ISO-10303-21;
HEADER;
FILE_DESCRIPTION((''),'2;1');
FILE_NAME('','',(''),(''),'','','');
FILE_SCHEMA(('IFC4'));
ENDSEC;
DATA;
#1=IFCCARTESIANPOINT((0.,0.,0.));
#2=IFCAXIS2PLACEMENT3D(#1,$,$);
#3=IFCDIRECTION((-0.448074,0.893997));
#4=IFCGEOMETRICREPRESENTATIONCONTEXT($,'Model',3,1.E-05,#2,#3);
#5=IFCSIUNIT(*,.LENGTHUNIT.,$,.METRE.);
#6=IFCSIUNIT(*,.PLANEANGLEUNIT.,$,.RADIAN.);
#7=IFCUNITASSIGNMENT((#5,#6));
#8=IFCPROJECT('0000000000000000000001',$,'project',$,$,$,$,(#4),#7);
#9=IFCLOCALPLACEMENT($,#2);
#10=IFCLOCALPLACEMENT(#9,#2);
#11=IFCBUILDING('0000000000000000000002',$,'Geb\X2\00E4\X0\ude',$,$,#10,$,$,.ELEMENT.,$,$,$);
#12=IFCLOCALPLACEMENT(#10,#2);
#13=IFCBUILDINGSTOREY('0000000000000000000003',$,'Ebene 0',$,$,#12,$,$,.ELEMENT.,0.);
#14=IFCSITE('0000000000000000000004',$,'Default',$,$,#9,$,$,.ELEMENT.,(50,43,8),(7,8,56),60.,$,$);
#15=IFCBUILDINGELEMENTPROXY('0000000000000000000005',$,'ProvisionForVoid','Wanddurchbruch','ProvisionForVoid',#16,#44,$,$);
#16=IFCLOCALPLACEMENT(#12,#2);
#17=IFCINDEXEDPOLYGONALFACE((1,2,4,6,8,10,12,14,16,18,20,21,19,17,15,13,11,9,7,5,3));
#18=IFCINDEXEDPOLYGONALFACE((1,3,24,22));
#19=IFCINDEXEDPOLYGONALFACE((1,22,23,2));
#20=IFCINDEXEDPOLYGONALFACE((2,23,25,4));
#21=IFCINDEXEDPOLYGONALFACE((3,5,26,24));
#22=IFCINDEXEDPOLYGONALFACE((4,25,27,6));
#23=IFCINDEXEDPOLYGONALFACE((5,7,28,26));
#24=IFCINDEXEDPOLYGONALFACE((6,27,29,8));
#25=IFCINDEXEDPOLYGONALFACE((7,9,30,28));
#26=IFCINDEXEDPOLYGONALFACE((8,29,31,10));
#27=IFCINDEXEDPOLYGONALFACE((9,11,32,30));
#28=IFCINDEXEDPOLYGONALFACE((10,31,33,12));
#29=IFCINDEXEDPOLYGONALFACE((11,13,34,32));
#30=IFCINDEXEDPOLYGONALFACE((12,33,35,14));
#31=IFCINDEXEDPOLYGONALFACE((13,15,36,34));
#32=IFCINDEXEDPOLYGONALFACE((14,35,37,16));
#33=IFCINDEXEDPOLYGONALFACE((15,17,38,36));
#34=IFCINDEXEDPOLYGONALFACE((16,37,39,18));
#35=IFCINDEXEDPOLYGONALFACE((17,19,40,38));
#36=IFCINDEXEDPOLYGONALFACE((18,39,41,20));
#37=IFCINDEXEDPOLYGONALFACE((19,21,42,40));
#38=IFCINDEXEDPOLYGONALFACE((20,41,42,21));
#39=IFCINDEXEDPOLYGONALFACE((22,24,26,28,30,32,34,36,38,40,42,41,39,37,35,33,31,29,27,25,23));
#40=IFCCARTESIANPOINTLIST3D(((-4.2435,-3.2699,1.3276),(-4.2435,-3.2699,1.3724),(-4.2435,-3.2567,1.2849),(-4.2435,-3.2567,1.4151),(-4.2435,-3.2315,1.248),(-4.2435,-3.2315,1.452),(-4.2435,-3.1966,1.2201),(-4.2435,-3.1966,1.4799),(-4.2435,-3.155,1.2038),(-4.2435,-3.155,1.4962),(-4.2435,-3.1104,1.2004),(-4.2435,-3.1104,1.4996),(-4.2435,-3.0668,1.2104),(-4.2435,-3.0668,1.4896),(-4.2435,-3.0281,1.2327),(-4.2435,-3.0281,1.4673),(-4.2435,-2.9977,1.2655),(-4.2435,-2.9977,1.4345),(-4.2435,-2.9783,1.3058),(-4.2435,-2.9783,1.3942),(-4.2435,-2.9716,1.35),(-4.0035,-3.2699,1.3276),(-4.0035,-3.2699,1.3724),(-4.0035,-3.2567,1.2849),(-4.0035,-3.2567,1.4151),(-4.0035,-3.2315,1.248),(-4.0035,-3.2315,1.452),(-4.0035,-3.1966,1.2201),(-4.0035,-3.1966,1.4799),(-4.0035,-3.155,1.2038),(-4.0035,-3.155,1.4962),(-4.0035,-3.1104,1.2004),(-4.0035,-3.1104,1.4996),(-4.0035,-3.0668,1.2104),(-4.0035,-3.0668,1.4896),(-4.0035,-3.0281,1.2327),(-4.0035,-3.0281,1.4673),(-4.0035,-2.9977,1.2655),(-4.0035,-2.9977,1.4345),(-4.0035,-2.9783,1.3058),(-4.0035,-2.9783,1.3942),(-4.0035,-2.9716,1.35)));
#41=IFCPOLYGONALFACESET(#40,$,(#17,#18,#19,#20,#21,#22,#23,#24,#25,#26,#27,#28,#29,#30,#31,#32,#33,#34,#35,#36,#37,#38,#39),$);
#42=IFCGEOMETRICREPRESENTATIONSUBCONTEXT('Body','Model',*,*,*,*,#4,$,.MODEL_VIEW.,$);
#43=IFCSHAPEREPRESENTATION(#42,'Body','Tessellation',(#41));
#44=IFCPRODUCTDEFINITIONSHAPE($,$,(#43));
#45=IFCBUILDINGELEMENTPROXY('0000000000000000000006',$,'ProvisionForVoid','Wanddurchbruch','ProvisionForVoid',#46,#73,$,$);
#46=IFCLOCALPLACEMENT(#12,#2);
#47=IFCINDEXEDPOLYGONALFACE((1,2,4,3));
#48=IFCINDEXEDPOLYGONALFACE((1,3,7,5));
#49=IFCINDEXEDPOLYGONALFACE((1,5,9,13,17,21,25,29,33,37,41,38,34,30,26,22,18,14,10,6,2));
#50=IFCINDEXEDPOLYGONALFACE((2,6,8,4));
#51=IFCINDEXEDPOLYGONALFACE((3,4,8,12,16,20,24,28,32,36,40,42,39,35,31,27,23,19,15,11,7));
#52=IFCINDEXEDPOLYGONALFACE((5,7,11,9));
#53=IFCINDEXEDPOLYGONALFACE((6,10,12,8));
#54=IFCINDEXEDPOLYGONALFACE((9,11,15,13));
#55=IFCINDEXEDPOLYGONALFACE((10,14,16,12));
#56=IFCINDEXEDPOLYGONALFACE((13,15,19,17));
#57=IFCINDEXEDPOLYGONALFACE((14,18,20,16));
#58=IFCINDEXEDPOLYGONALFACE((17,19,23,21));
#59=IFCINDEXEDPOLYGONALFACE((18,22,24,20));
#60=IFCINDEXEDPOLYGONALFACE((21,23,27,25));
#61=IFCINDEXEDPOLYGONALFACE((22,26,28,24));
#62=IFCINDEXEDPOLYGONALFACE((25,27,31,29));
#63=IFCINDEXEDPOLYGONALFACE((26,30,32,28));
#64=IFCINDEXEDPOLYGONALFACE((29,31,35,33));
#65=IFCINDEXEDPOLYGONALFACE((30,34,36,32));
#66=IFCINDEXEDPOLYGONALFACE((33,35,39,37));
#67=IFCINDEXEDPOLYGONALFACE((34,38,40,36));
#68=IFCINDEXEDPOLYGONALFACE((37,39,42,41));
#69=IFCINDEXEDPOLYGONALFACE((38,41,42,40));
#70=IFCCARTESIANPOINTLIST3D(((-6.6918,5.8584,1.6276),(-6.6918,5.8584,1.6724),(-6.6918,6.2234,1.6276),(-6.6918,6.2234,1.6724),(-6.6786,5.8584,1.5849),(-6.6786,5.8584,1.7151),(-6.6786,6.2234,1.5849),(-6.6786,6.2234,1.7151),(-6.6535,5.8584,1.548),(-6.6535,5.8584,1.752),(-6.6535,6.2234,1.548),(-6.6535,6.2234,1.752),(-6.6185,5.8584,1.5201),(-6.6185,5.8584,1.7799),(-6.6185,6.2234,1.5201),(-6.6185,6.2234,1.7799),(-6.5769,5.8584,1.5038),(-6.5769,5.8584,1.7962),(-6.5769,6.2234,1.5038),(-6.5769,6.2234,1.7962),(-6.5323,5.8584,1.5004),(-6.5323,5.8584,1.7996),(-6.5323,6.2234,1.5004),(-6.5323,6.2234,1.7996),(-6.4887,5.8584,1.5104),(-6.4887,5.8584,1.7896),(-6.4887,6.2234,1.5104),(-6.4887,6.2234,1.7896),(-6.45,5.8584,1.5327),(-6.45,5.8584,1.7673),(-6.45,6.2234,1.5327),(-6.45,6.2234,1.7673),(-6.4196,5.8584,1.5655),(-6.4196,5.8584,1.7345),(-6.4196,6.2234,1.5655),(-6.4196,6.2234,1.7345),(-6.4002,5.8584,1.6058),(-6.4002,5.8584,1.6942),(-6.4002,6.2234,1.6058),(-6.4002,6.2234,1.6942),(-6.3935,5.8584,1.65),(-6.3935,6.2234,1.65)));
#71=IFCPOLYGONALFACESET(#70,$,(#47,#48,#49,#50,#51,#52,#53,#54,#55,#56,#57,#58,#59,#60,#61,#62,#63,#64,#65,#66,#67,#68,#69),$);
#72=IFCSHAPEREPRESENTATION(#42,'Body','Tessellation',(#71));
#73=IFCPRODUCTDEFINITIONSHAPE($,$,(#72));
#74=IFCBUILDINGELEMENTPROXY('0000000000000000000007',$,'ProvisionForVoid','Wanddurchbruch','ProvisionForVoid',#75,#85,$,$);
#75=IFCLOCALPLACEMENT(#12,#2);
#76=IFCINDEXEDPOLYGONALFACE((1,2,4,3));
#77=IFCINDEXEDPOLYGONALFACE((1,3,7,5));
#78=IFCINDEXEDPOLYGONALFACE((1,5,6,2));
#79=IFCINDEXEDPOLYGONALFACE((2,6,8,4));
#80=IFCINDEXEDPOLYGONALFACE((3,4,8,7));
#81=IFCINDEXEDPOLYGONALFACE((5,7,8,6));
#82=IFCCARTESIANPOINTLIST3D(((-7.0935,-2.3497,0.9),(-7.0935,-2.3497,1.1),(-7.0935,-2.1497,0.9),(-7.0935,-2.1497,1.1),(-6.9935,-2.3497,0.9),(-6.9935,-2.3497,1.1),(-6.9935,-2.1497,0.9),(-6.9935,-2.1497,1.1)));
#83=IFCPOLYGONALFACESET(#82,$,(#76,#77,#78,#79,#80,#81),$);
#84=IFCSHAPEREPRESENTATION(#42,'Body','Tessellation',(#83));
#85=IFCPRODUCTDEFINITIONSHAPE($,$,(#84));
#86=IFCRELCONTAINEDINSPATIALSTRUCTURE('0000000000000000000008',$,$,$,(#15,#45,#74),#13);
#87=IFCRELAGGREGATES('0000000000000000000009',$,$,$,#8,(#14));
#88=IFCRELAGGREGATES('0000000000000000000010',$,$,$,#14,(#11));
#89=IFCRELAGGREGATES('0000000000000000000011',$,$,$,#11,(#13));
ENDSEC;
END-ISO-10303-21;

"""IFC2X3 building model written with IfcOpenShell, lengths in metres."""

from ifc_helpers import new_model, si_unit, direction, frame, frame_2d, origin, place, context, subcontext, project, spatial, rectangle, circle, extrude, element, save


model = new_model("IFC2X3")

# Units and contexts
model_context = context("Model", 3, precision=1e-05, world=origin(), true_north=direction((-0.448074, 0.893997)))
body_context = subcontext(model_context, "Body", "Model", "MODEL_VIEW")
ifc_project = project(units=[si_unit("LENGTHUNIT", "METRE"), si_unit("PLANEANGLEUNIT", "RADIAN")], contexts=[model_context])

# Site, building, storey
site_placement = place(None, origin())
site = spatial("IfcSite", under=ifc_project, at=site_placement, Name="Default", CompositionType="ELEMENT", RefLatitude=(50, 43, 8), RefLongitude=(7, 8, 56), RefElevation=60.0)
building_placement = place(site_placement, origin())
building = spatial("IfcBuilding", under=site, at=building_placement, Name="Gebäude", CompositionType="ELEMENT")
storey_placement = place(building_placement, origin())
storey = spatial("IfcBuildingStorey", under=building, at=storey_placement, Name="Ebene 0", CompositionType="ELEMENT", Elevation=0.0)

# Building element proxies
proxy_1_placement = place(storey_placement, origin())
element("IfcBuildingElementProxy", 1, at=proxy_1_placement, inside=storey, Name="ProvisionForVoid", Description="Wanddurchbruch", ObjectType="ProvisionForVoid", context=body_context, shape_type="SweptSolid", body=[
    extrude(circle(Radius=0.15, at=frame_2d((0.0, 0.0), x_axis=(1.0, 0.0))), frame((-4.2435, -3.1216, 1.35), z_axis=(1.0, 0.0, 0.0), x_axis=(0.0, 1.0, 0.0)), (0.0, 0.0, 1.0), 0.24),
])
proxy_2_placement = place(storey_placement, origin())
element("IfcBuildingElementProxy", 2, at=proxy_2_placement, inside=storey, Name="ProvisionForVoid", Description="Wanddurchbruch", ObjectType="ProvisionForVoid", context=body_context, shape_type="SweptSolid", body=[
    extrude(circle(Radius=0.15, at=frame_2d((0.0, 0.0), x_axis=(1.0, 0.0))), frame((-6.5435, 5.8584, 1.65), z_axis=(0.0, 1.0, 0.0), x_axis=(1.0, 0.0, 0.0)), (0.0, 0.0, 1.0), 0.365),
])
proxy_3_placement = place(storey_placement, origin())
element("IfcBuildingElementProxy", 3, at=proxy_3_placement, inside=storey, Name="ProvisionForVoid", Description="Wanddurchbruch", ObjectType="ProvisionForVoid", context=body_context, shape_type="SweptSolid", body=[
    extrude(rectangle(XDim=0.2, YDim=0.2, at=frame_2d((0.0, 0.0), x_axis=(1.0, 0.0))), frame((-7.0935, -2.2497, 1.0), z_axis=(1.0, 0.0, 0.0), x_axis=(0.0, 1.0, 0.0)), (0.0, 0.0, 1.0), 0.1),
])

save(model, "model.ifc")
